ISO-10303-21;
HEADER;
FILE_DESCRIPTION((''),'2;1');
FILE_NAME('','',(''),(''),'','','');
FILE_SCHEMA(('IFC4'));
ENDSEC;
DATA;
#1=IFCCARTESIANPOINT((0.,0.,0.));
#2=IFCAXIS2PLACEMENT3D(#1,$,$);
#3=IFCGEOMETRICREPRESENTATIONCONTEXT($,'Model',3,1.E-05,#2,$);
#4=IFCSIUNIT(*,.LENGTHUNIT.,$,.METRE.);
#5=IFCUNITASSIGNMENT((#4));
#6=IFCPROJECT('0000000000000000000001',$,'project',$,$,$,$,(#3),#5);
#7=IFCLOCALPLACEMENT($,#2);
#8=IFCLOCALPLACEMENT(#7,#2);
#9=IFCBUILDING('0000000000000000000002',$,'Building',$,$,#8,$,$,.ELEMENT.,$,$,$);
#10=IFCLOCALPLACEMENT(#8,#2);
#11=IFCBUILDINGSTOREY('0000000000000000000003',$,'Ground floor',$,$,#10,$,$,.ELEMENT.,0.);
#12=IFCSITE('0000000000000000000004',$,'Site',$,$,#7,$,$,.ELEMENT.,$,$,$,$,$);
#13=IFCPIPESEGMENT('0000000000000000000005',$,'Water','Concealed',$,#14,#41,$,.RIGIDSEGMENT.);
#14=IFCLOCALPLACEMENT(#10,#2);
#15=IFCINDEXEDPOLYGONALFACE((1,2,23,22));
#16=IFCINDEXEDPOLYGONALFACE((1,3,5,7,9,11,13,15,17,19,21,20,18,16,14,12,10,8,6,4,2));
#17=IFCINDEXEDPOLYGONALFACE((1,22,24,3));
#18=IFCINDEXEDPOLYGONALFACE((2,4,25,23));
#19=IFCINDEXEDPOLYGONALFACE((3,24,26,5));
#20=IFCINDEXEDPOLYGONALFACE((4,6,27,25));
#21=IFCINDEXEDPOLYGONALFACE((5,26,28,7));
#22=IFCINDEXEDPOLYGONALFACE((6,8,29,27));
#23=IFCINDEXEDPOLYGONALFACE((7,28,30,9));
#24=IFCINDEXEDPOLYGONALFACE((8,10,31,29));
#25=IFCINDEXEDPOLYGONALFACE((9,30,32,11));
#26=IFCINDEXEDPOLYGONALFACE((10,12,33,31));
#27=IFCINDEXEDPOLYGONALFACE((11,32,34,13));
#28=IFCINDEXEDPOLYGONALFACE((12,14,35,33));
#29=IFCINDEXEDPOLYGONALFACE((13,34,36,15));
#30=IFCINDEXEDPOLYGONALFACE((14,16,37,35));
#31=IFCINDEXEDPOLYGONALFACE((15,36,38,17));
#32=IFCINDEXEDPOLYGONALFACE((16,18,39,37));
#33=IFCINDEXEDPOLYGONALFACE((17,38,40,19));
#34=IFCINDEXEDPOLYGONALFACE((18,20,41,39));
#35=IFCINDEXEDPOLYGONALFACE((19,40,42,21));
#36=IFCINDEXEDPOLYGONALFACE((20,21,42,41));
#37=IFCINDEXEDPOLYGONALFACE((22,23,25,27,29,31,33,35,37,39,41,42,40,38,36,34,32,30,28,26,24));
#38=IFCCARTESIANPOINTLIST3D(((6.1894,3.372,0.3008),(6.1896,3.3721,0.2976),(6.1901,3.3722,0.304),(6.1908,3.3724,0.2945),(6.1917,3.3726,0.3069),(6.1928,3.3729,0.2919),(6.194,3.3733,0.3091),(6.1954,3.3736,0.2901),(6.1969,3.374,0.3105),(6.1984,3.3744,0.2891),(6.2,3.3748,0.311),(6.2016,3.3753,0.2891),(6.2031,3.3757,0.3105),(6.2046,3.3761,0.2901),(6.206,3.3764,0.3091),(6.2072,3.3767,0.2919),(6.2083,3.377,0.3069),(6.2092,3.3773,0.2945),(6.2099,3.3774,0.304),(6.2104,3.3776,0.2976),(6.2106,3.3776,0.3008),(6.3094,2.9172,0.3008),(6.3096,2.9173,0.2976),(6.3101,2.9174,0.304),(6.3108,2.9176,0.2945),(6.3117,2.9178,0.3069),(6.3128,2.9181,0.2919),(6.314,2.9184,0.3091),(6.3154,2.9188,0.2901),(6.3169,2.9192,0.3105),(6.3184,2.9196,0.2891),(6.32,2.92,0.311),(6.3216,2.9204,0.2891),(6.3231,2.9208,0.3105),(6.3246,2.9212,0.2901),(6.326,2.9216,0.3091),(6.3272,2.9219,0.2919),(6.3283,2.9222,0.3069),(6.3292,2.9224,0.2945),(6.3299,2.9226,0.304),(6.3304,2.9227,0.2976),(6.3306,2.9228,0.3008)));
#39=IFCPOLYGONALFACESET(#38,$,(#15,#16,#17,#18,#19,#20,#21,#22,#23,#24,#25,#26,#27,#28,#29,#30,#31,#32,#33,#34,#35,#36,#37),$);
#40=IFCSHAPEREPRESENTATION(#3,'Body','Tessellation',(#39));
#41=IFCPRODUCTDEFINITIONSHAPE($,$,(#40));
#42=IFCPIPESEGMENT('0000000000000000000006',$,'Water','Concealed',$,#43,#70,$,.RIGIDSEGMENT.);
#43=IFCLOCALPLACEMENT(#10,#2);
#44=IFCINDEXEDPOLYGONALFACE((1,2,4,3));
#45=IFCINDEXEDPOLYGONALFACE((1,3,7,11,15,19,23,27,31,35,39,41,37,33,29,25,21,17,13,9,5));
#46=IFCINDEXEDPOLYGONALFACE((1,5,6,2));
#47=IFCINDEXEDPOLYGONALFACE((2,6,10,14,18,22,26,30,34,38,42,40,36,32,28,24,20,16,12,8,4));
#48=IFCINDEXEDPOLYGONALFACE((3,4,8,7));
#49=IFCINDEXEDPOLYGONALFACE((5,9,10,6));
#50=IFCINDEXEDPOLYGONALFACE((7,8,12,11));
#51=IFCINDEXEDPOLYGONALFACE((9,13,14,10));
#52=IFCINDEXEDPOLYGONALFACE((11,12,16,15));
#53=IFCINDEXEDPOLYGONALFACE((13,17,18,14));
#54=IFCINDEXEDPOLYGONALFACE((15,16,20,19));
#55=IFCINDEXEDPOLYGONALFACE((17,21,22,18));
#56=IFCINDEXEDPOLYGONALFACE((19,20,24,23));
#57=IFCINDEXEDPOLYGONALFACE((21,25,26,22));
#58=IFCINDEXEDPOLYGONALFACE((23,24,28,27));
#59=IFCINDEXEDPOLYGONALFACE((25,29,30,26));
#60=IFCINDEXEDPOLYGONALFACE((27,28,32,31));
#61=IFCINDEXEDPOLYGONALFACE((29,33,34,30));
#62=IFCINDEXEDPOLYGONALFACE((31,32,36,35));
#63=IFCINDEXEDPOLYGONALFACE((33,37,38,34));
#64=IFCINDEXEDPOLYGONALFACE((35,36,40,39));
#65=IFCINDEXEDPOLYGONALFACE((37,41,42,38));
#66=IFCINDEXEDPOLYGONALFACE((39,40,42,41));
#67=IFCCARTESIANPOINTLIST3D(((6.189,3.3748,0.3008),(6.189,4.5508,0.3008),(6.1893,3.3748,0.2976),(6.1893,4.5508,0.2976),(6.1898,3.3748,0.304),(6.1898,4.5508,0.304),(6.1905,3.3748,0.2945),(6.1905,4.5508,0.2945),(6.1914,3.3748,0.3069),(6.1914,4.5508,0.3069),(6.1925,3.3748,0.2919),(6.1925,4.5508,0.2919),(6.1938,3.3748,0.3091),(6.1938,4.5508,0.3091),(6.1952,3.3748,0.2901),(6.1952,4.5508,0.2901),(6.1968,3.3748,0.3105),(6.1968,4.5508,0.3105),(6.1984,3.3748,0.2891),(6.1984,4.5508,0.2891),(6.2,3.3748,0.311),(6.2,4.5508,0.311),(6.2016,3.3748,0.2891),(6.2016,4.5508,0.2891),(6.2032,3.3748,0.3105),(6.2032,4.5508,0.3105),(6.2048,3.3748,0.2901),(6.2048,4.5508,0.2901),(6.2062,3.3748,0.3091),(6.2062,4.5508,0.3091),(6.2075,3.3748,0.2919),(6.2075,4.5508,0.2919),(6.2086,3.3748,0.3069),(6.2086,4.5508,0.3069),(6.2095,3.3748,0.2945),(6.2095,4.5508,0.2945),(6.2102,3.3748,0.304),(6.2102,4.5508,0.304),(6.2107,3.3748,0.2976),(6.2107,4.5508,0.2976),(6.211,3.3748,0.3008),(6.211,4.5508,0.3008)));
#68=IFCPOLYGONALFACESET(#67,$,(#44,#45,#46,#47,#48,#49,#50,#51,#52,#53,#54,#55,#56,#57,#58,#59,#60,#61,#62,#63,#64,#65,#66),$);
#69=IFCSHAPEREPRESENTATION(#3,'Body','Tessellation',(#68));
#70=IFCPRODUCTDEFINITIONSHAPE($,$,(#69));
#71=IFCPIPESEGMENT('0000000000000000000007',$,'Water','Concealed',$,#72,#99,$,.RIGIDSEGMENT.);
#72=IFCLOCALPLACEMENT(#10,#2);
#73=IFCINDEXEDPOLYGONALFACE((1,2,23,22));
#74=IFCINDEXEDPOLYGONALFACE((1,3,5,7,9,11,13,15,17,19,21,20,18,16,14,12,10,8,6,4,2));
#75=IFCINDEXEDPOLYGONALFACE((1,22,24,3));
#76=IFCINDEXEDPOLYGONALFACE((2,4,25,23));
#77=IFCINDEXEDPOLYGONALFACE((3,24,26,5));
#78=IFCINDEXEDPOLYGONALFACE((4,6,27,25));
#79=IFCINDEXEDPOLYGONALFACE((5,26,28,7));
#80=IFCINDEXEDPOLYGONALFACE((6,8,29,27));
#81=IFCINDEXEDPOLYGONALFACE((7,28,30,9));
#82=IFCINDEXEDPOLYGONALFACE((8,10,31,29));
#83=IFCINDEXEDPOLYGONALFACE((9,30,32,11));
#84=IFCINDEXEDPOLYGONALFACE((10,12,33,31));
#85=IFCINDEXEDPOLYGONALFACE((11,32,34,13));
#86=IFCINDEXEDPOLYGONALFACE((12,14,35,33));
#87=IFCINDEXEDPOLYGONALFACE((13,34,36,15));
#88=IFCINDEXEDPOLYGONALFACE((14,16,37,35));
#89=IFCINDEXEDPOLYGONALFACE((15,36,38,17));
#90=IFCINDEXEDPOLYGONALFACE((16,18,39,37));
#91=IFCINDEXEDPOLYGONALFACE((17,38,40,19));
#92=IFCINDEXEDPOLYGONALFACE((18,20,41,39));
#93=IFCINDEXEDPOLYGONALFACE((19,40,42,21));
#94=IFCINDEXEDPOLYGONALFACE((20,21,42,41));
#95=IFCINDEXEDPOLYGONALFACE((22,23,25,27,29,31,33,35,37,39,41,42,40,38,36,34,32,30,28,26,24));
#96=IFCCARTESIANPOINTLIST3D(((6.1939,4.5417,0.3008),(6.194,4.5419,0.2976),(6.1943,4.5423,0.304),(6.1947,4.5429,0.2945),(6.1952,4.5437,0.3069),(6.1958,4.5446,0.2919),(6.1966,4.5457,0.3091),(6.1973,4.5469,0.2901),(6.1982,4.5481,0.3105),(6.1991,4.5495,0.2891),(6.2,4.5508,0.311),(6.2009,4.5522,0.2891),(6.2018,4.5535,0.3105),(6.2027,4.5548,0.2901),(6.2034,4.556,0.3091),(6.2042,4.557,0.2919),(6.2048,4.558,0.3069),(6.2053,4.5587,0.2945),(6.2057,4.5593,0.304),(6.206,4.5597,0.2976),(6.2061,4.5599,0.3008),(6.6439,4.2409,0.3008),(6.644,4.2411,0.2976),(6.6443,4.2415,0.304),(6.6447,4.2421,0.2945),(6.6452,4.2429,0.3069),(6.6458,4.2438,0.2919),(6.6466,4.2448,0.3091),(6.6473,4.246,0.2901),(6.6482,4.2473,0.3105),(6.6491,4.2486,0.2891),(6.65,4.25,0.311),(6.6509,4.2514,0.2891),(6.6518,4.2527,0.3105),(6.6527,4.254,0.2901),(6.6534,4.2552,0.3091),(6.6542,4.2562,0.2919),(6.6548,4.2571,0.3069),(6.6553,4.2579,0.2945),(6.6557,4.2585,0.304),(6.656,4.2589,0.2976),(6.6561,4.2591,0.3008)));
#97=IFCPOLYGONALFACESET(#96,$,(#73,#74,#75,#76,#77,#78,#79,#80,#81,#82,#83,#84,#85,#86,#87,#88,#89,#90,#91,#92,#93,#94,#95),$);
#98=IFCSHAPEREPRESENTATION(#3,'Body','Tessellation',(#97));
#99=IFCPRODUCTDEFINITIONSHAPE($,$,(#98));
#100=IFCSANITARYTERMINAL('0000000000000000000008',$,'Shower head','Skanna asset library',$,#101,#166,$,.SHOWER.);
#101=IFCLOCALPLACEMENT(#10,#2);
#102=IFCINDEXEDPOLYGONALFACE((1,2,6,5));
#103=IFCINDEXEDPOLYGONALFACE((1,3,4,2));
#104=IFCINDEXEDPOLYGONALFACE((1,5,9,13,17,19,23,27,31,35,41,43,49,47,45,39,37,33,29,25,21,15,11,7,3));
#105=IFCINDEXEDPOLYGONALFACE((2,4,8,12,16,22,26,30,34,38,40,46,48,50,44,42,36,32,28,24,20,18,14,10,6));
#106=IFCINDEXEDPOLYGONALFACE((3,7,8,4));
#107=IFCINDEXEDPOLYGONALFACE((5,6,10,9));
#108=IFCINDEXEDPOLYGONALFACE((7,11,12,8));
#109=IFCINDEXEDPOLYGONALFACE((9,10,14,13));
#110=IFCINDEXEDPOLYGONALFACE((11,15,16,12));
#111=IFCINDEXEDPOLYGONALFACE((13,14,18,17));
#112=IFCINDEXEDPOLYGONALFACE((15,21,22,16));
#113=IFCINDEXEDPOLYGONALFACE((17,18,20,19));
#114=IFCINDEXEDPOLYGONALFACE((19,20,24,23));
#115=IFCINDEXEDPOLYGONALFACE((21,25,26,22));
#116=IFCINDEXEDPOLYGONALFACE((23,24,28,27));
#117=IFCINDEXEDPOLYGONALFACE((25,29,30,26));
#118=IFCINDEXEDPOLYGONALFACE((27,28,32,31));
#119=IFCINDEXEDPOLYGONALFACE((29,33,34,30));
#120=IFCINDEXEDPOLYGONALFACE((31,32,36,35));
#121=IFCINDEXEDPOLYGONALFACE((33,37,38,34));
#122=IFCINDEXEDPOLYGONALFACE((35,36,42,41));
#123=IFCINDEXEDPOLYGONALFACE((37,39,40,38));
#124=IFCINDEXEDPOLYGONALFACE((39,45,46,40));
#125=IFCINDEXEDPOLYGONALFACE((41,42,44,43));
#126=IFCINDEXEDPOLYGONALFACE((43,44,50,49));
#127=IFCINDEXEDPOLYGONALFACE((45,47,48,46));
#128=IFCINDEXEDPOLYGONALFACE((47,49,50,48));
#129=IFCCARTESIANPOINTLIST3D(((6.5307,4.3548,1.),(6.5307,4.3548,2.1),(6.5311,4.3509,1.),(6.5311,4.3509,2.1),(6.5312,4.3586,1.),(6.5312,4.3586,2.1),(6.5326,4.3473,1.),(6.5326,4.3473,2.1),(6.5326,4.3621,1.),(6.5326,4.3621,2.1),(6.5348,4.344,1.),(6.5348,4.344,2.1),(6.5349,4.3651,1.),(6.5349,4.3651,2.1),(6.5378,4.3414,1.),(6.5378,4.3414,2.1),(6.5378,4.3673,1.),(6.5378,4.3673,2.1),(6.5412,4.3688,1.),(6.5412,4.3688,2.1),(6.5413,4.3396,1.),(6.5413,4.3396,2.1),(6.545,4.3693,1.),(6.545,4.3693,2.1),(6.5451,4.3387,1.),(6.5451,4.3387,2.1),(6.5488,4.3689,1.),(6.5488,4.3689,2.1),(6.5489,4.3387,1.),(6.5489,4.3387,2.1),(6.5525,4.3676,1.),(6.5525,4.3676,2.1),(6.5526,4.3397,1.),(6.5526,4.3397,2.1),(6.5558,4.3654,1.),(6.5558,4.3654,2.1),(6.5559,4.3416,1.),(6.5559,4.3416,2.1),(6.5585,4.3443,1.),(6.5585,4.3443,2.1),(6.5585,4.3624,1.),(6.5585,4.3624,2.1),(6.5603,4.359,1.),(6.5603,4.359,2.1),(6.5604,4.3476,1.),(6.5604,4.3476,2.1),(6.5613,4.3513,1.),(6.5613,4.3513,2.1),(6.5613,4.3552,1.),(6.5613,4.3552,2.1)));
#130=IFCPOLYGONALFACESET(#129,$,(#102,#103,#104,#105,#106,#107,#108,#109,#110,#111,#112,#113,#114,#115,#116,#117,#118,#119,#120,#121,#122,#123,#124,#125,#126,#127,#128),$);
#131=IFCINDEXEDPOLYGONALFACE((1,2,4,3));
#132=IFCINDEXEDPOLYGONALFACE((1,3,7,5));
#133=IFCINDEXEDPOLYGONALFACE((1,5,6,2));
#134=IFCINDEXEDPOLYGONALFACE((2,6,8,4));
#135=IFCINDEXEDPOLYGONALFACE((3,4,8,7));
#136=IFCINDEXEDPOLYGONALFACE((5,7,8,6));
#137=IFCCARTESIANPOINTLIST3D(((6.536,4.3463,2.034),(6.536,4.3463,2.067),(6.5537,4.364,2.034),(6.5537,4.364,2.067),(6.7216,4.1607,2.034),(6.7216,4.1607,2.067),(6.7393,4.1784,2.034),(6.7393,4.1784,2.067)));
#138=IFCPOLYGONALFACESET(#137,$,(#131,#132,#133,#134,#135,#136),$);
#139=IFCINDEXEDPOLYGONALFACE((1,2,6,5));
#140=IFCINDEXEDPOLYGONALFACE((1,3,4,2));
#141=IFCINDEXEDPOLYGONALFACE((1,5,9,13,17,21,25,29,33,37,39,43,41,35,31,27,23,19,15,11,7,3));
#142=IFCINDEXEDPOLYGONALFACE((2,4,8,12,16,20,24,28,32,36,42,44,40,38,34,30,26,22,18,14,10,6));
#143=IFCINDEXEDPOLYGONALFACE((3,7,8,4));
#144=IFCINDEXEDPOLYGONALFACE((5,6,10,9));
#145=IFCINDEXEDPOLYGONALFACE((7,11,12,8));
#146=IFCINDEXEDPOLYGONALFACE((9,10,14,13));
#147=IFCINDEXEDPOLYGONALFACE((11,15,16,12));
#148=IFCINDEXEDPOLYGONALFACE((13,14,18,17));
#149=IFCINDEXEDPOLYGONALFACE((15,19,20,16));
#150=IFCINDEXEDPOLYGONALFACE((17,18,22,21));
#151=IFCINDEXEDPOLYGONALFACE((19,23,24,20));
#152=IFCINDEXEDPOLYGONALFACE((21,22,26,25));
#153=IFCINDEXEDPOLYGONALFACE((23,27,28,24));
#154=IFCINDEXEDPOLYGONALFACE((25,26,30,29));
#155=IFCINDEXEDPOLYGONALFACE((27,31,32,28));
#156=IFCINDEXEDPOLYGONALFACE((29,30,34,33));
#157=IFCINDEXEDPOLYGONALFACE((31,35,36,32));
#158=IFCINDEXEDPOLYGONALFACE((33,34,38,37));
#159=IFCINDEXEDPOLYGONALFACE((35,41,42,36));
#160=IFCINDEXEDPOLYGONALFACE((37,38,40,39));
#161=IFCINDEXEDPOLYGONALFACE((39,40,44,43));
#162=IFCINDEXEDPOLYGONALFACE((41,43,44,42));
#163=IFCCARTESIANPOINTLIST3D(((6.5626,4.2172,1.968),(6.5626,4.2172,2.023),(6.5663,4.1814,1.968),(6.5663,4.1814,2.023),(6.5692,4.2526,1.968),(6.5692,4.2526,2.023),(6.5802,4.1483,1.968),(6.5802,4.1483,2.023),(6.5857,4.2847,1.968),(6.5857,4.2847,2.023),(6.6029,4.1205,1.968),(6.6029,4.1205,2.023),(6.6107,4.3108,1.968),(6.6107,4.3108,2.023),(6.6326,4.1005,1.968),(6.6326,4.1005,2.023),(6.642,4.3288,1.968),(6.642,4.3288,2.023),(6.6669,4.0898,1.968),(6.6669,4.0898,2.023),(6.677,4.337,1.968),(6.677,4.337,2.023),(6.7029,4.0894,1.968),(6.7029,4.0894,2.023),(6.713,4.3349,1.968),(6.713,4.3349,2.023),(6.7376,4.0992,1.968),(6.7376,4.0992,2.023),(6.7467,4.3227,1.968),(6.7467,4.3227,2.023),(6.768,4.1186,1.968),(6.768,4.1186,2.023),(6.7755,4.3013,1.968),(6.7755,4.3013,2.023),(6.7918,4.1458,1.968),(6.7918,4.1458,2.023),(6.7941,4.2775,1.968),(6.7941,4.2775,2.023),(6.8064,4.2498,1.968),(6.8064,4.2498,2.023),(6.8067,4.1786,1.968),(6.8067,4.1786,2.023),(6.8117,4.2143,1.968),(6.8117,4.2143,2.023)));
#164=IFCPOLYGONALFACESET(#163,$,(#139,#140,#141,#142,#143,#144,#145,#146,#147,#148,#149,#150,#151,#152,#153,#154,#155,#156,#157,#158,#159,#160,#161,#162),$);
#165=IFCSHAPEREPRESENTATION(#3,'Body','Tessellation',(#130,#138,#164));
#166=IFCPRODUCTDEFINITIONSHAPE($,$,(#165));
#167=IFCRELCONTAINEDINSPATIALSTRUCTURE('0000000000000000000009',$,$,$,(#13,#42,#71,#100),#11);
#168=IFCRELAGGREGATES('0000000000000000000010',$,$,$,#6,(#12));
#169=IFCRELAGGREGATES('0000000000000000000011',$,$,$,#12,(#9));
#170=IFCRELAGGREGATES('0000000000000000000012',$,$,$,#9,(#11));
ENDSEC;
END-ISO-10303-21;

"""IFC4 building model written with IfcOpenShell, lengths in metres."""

from ifc_helpers import new_model, si_unit, frame, frame_2d, origin, origin_2d, place, context, project, spatial, rectangle, circle, ellipse, extrude, element, save


model = new_model("IFC4")

# Units and contexts
model_context = context("Model", 3, precision=1e-05, world=origin())
ifc_project = project(units=[si_unit("LENGTHUNIT", "METRE")], contexts=[model_context])

# Site, building, storey
site_placement = place(None, origin())
site = spatial("IfcSite", under=ifc_project, at=site_placement, Name="Site", CompositionType="ELEMENT")
building_placement = place(site_placement, origin())
building = spatial("IfcBuilding", under=site, at=building_placement, Name="Building", CompositionType="ELEMENT")
storey_placement = place(building_placement, origin())
storey = spatial("IfcBuildingStorey", under=building, at=storey_placement, Name="Ground floor", CompositionType="ELEMENT", Elevation=0.0)

# Pipe segments
pipe_segment_1_placement = place(storey_placement, frame((6.32, 2.92, 0.3), z_axis=(-0.255102, 0.966914, 0.0), x_axis=(0.0, 0.0, 1.0)))
element("IfcPipeSegment", 1, at=pipe_segment_1_placement, inside=storey, Name="Water", Description="Concealed", PredefinedType="RIGIDSEGMENT", context=model_context, shape_type="SweptSolid", body=[
    extrude(circle(Radius=0.011, at=origin_2d()), origin(), (0.0, 0.0, 1.0), 0.4704),
])
pipe_segment_2_placement = place(storey_placement, frame((6.2, 3.3748, 0.3), z_axis=(0.0, 1.0, 0.0), x_axis=(0.0, 0.0, 1.0)))
element("IfcPipeSegment", 2, at=pipe_segment_2_placement, inside=storey, Name="Water", Description="Concealed", PredefinedType="RIGIDSEGMENT", context=model_context, shape_type="SweptSolid", body=[
    extrude(circle(Radius=0.011, at=origin_2d()), origin(), (0.0, 0.0, 1.0), 1.176),
])
pipe_segment_3_placement = place(storey_placement, frame((6.2, 4.5508, 0.3), z_axis=(0.831345, -0.555757, 0.0), x_axis=(0.0, 0.0, 1.0)))
element("IfcPipeSegment", 3, at=pipe_segment_3_placement, inside=storey, Name="Water", Description="Concealed", PredefinedType="RIGIDSEGMENT", context=model_context, shape_type="SweptSolid", body=[
    extrude(circle(Radius=0.011, at=origin_2d()), origin(), (0.0, 0.0, 1.0), 0.5413),
])

# Sanitary terminal
sanitary_terminal_1_placement = place(storey_placement, frame((6.65, 4.25, 1.0), z_axis=(0.0, 0.0, 1.0), x_axis=(0.707107, 0.707107, 0.0)))
element("IfcSanitaryTerminal", 4, at=sanitary_terminal_1_placement, inside=storey, Name="Shower head", Description="Skanna asset library", PredefinedType="SHOWER", context=model_context, shape_type="SweptSolid", body=[
    extrude(ellipse(SemiAxis1=0.015, SemiAxis2=0.0158, at=frame_2d((0.0, 0.147))), origin(), (0.0, 0.0, 1.0), 1.1),
    extrude(rectangle(XDim=0.025, YDim=0.2625, at=frame_2d((0.0, 0.0175))), frame((0.0, 0.0, 1.034)), (0.0, 0.0, 1.0), 0.033),
    extrude(ellipse(SemiAxis1=0.125, SemiAxis2=0.1242, at=frame_2d((0.0, -0.0525))), frame((0.0, 0.0, 0.968)), (0.0, 0.0, 1.0), 0.055),
])

save(model, "model.ifc")
